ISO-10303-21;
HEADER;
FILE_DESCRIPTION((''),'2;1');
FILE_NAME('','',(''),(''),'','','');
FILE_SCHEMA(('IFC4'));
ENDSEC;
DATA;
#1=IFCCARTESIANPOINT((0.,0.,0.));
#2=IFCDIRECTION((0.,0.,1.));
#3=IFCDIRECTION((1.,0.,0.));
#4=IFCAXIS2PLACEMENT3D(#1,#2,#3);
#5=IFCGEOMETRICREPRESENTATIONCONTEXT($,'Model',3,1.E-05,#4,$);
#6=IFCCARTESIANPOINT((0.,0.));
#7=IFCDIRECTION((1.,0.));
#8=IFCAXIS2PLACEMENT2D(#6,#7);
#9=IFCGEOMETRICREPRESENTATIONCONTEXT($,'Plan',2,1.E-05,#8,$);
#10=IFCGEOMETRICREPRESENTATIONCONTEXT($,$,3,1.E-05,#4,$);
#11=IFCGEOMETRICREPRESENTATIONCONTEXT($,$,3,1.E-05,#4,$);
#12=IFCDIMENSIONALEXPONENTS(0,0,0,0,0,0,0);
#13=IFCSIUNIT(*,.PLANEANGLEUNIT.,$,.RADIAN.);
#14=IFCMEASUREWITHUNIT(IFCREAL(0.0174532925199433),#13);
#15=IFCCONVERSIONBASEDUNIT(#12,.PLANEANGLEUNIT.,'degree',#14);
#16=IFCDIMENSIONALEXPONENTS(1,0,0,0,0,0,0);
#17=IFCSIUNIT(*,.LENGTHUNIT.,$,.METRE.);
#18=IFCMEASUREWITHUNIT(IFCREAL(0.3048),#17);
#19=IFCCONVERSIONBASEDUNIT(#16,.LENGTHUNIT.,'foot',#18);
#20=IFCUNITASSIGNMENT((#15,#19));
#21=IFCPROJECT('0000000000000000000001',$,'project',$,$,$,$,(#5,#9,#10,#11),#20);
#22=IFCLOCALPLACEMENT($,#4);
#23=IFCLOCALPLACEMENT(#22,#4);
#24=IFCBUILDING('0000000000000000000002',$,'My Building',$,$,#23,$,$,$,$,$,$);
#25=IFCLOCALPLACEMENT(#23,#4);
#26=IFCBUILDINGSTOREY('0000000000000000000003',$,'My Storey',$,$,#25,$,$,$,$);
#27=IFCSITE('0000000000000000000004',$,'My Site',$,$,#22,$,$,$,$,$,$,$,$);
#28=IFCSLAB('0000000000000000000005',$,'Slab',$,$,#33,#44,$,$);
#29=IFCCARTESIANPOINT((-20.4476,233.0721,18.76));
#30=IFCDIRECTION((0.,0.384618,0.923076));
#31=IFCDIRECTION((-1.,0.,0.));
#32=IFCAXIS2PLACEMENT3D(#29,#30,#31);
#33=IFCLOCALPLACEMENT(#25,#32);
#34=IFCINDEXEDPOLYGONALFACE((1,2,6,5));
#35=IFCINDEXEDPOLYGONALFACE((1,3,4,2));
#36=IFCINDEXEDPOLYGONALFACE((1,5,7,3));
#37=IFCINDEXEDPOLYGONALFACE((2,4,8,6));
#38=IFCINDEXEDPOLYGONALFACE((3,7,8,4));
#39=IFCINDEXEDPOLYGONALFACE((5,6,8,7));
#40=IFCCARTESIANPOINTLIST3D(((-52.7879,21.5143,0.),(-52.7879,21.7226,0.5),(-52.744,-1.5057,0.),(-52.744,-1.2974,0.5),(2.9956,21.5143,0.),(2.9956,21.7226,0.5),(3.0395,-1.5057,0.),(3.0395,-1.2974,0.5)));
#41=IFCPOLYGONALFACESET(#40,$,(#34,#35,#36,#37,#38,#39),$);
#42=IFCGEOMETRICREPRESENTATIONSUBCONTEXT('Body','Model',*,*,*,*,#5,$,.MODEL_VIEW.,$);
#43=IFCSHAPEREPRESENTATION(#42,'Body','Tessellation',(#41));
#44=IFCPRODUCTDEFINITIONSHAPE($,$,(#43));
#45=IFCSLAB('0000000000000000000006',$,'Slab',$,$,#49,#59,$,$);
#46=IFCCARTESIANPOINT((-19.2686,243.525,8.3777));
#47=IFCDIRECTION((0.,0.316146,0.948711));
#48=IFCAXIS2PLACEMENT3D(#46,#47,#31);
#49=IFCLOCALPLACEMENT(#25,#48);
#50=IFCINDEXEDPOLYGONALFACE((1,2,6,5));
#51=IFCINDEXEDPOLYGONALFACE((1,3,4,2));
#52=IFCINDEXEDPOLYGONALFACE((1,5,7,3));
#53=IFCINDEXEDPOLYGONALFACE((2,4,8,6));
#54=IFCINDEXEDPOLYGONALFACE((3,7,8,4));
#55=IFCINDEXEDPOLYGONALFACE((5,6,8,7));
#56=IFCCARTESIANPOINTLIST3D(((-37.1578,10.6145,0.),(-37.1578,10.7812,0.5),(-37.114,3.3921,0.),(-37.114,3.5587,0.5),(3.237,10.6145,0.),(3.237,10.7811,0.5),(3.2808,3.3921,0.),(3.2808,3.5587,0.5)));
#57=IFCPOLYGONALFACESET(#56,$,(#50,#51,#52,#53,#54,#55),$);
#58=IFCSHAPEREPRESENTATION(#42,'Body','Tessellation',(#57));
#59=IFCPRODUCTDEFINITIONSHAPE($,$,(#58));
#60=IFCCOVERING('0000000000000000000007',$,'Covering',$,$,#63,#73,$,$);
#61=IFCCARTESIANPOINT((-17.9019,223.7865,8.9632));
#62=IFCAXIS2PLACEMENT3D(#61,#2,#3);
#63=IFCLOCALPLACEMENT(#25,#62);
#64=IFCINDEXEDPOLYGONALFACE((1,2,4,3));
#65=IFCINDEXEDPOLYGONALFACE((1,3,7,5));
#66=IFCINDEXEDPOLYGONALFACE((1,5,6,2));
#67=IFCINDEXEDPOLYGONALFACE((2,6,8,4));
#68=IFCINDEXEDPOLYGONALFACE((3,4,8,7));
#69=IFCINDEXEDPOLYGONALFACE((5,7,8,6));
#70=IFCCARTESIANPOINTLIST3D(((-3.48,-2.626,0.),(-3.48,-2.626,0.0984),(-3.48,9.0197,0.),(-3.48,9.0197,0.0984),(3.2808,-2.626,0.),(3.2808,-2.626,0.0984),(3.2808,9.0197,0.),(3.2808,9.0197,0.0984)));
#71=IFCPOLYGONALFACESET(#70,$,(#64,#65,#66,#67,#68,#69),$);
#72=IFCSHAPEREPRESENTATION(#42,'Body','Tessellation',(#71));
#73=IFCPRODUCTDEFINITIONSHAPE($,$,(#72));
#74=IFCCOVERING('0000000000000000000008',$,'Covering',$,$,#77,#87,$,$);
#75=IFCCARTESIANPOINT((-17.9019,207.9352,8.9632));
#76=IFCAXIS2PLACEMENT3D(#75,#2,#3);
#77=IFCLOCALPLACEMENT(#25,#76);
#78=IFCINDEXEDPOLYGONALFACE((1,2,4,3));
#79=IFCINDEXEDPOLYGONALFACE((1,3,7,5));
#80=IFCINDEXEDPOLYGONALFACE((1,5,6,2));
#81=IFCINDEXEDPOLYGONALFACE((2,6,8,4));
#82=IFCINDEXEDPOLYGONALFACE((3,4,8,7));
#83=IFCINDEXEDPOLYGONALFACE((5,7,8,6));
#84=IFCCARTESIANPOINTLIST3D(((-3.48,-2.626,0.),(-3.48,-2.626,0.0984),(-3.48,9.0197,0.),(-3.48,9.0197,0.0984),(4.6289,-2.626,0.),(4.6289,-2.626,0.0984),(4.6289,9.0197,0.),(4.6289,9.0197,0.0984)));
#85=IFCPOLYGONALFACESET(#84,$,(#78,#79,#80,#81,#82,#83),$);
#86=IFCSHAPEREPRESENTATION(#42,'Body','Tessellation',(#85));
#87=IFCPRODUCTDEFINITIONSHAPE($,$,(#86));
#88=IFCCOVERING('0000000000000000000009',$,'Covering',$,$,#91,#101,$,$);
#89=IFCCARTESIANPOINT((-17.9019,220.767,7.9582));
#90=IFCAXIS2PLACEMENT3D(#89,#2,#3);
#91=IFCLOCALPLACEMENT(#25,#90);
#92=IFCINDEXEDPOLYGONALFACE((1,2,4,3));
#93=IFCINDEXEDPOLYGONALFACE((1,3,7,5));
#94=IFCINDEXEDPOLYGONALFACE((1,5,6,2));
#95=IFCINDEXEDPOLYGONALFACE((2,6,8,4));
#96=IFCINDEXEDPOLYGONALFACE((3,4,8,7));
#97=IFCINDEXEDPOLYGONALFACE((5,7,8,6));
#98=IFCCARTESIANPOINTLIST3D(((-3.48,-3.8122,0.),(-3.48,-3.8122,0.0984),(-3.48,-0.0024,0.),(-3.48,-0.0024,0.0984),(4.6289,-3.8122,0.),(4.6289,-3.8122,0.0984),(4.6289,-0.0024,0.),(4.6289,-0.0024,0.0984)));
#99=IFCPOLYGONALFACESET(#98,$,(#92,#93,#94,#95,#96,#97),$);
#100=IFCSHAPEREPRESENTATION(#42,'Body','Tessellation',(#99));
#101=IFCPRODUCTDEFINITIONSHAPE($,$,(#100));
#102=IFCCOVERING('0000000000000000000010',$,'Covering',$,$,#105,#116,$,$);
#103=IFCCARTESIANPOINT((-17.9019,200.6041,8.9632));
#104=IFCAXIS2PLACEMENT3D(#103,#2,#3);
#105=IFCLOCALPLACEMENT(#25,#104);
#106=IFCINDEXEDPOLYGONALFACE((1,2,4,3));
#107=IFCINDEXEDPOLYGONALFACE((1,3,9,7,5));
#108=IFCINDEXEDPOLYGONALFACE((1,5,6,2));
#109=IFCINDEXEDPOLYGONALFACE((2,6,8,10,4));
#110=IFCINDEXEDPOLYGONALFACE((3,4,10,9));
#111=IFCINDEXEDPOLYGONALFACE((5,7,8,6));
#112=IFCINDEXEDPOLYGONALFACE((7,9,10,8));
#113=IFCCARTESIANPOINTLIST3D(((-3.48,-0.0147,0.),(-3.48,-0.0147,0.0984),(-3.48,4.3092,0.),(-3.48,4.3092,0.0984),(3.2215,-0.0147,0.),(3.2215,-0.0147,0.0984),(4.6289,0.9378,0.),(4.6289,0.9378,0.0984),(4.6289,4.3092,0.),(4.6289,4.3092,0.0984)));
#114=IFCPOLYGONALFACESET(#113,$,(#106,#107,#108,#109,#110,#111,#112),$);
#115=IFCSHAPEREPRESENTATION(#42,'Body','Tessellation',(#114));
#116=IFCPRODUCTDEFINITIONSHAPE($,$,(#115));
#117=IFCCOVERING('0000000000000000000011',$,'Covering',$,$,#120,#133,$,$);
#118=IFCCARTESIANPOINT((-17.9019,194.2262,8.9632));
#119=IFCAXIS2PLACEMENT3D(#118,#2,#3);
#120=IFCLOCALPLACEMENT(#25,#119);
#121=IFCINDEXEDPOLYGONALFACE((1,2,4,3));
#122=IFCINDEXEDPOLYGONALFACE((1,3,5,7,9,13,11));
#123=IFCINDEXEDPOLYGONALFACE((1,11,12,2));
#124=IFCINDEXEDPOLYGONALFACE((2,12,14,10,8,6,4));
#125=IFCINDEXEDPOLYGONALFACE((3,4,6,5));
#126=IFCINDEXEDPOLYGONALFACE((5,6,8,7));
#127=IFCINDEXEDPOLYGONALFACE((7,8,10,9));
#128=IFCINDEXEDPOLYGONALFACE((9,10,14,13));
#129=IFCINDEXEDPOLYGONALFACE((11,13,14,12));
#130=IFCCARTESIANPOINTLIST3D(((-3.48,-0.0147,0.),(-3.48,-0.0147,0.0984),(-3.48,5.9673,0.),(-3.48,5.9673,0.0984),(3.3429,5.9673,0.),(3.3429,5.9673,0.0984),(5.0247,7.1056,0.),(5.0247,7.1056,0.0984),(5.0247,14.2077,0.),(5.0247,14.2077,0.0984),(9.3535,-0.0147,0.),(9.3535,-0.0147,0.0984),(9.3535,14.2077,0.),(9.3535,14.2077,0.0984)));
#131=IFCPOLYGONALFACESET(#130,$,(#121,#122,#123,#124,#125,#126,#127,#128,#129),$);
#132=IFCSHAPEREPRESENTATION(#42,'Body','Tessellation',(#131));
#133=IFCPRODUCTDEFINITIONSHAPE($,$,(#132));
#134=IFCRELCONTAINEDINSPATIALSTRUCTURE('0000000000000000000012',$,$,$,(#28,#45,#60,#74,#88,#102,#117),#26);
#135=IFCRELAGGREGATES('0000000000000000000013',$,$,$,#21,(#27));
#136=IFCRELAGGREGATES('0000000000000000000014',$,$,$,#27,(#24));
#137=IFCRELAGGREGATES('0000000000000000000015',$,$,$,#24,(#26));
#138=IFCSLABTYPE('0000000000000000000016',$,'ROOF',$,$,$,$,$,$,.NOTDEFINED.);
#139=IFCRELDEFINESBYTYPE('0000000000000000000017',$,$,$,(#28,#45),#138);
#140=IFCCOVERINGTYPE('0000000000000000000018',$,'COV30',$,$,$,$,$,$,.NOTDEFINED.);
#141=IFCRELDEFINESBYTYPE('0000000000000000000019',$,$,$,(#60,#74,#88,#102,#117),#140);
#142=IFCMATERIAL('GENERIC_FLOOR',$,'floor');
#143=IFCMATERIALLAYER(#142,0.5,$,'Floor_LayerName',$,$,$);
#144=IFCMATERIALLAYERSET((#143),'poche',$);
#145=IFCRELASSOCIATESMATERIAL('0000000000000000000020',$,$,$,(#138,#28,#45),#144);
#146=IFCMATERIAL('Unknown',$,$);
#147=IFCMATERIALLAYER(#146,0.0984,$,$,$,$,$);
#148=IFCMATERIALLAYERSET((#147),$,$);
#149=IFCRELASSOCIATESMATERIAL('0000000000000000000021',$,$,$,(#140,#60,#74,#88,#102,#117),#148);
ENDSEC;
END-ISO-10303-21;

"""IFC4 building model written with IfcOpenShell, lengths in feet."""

from ifc_helpers import new_model, entity, si_unit, converted_unit, frame, origin_with_axes, origin_2d_with_axis, place, context, subcontext, project, spatial, line, indexed_curve, outline, extrude, material, layer, layer_set, layer_usage, type_object, element, save


model = new_model("IFC4")

# Units and contexts
model_context = context("Model", 3, precision=1e-05, world=origin_with_axes())
plan_context = context("Plan", 2, precision=1e-05, world=origin_2d_with_axis())
context_of_model_1 = context(None, 3, precision=1e-05, world=origin_with_axes())
context_of_model_2 = context(None, 3, precision=1e-05, world=origin_with_axes())
body_context = subcontext(model_context, "Body", "Model", "MODEL_VIEW")
ifc_project = project(units=[converted_unit("PLANEANGLEUNIT", "degree", entity("IfcReal", 0.0174532925199433), si_unit("PLANEANGLEUNIT", "RADIAN"), dimensions=[0, 0, 0, 0, 0, 0, 0]), converted_unit("LENGTHUNIT", "foot", entity("IfcReal", 0.3048), si_unit("LENGTHUNIT", "METRE"), dimensions=[1, 0, 0, 0, 0, 0, 0])], contexts=[model_context, plan_context, context_of_model_1, context_of_model_2])

# Site, building, storey
site_placement = place(None, origin_with_axes())
site = spatial("IfcSite", under=ifc_project, at=site_placement, Name="My Site")
building_placement = place(site_placement, origin_with_axes())
building = spatial("IfcBuilding", under=site, at=building_placement, Name="My Building")
storey_placement = place(building_placement, origin_with_axes())
storey = spatial("IfcBuildingStorey", under=building, at=storey_placement, Name="My Storey")

# Slabs
ifc_material_1 = material(Name="GENERIC_FLOOR", Category="floor")
ifc_layer_1 = layer(ifc_material_1, 0.5, Name="Floor_LayerName")
ifc_layer_set_1 = layer_set([ifc_layer_1], Name="poche")
ifc_layer_usage_1 = layer_usage(ifc_layer_set_1, "AXIS3", "POSITIVE", 0.0)
slab_type_1 = type_object("IfcSlabType", Name="ROOF", PredefinedType="NOTDEFINED", material=ifc_layer_set_1)
slab_1_placement = place(storey_placement, frame((-20.4476, 233.0721, 18.76), z_axis=(0.0, 0.384618, 0.923076), x_axis=(-1.0, 0.0, 0.0)))
element("IfcSlab", 1, at=slab_1_placement, inside=storey, type_object=slab_type_1, material=ifc_layer_usage_1, Name="Slab", context=body_context, shape_type="SweptSolid", body=[
    extrude(outline(indexed_curve([(2.9956, 21.5143), (3.0395, -1.5057), (-52.744, -1.5057), (-52.7879, 21.5143)], segments=[line(3, 2), line(2, 1), line(1, 4), line(4, 3)], self_intersect=False)), None, (0.0, 0.384618, 0.923076), 0.5417),
])
ifc_layer_usage_2 = layer_usage(ifc_layer_set_1, "AXIS3", "POSITIVE", 0.0)
slab_2_placement = place(storey_placement, frame((-19.2686, 243.525, 8.3777), z_axis=(0.0, 0.316146, 0.948711), x_axis=(-1.0, 0.0, 0.0)))
element("IfcSlab", 2, at=slab_2_placement, inside=storey, type_object=slab_type_1, material=ifc_layer_usage_2, Name="Slab", context=body_context, shape_type="SweptSolid", body=[
    extrude(outline(indexed_curve([(-37.1578, 10.6145), (3.237, 10.6145), (3.2808, 3.3921), (-37.114, 3.3921)], segments=[line(4, 1), line(1, 2), line(2, 3), line(3, 4)], self_intersect=False)), None, (0.0, 0.316146, 0.948711), 0.527),
])

# Coverings
ifc_material_2 = material(Name="Unknown")
ifc_layer_2 = layer(ifc_material_2, 0.0984)
ifc_layer_set_2 = layer_set([ifc_layer_2])
ifc_layer_usage_3 = layer_usage(ifc_layer_set_2, "AXIS3", "POSITIVE", 0.0)
covering_type_1 = type_object("IfcCoveringType", Name="COV30", PredefinedType="NOTDEFINED", material=ifc_layer_set_2)
covering_1_placement = place(storey_placement, frame((-17.9019, 223.7865, 8.9632), z_axis=(0.0, 0.0, 1.0), x_axis=(1.0, 0.0, 0.0)))
element("IfcCovering", 3, at=covering_1_placement, inside=storey, type_object=covering_type_1, material=ifc_layer_usage_3, Name="Covering", context=body_context, shape_type="SweptSolid", body=[
    extrude(outline(indexed_curve([(-3.48, -2.626), (3.2808, -2.626), (3.2808, 9.0197), (-3.48, 9.0197)], segments=[line(4, 1), line(1, 2), line(2, 3), line(3, 4)], self_intersect=False)), None, (0.0, 0.0, 1.0), 0.0984),
])
ifc_layer_usage_4 = layer_usage(ifc_layer_set_2, "AXIS3", "POSITIVE", 0.0)
covering_2_placement = place(storey_placement, frame((-17.9019, 207.9352, 8.9632), z_axis=(0.0, 0.0, 1.0), x_axis=(1.0, 0.0, 0.0)))
element("IfcCovering", 4, at=covering_2_placement, inside=storey, type_object=covering_type_1, material=ifc_layer_usage_4, Name="Covering", context=body_context, shape_type="SweptSolid", body=[
    extrude(outline(indexed_curve([(-3.48, 9.0197), (-3.48, -2.626), (4.6289, -2.626), (4.6289, 9.0197)], segments=[line(4, 1), line(1, 2), line(2, 3), line(3, 4)], self_intersect=False)), None, (0.0, 0.0, 1.0), 0.0984),
])
ifc_layer_usage_5 = layer_usage(ifc_layer_set_2, "AXIS3", "POSITIVE", 0.0)
covering_3_placement = place(storey_placement, frame((-17.9019, 220.767, 7.9582), z_axis=(0.0, 0.0, 1.0), x_axis=(1.0, 0.0, 0.0)))
element("IfcCovering", 5, at=covering_3_placement, inside=storey, type_object=covering_type_1, material=ifc_layer_usage_5, Name="Covering", context=body_context, shape_type="SweptSolid", body=[
    extrude(outline(indexed_curve([(-3.48, -0.0024), (4.6289, -0.0024), (4.6289, -3.8122), (-3.48, -3.8122)], segments=[line(4, 1), line(1, 2), line(2, 3), line(3, 4)], self_intersect=False)), None, (0.0, 0.0, 1.0), 0.0984),
])
ifc_layer_usage_6 = layer_usage(ifc_layer_set_2, "AXIS3", "POSITIVE", 0.0)
covering_4_placement = place(storey_placement, frame((-17.9019, 200.6041, 8.9632), z_axis=(0.0, 0.0, 1.0), x_axis=(1.0, 0.0, 0.0)))
element("IfcCovering", 6, at=covering_4_placement, inside=storey, type_object=covering_type_1, material=ifc_layer_usage_6, Name="Covering", context=body_context, shape_type="SweptSolid", body=[
    extrude(outline(indexed_curve([(4.6289, 0.9378), (4.6289, 4.3092), (-3.48, 4.3092), (-3.48, -0.0147), (3.2215, -0.0147)], segments=[line(3, 4), line(4, 5), line(5, 1), line(1, 2), line(2, 3)], self_intersect=False)), None, (0.0, 0.0, 1.0), 0.0984),
])
ifc_layer_usage_7 = layer_usage(ifc_layer_set_2, "AXIS3", "POSITIVE", 0.0)
covering_5_placement = place(storey_placement, frame((-17.9019, 194.2262, 8.9632), z_axis=(0.0, 0.0, 1.0), x_axis=(1.0, 0.0, 0.0)))
element("IfcCovering", 7, at=covering_5_placement, inside=storey, type_object=covering_type_1, material=ifc_layer_usage_7, Name="Covering", context=body_context, shape_type="SweptSolid", body=[
    extrude(outline(indexed_curve([(-3.48, 5.9673), (-3.48, -0.0147), (9.3535, -0.0147), (9.3535, 14.2077), (5.0247, 7.1056), (3.3429, 5.9673), (5.0247, 14.2077)], segments=[line(1, 6), line(6, 5), line(5, 7), line(7, 4), line(4, 3), line(3, 2), line(2, 1)], self_intersect=False)), None, (0.0, 0.0, 1.0), 0.0984),
])

save(model, "model.ifc")
